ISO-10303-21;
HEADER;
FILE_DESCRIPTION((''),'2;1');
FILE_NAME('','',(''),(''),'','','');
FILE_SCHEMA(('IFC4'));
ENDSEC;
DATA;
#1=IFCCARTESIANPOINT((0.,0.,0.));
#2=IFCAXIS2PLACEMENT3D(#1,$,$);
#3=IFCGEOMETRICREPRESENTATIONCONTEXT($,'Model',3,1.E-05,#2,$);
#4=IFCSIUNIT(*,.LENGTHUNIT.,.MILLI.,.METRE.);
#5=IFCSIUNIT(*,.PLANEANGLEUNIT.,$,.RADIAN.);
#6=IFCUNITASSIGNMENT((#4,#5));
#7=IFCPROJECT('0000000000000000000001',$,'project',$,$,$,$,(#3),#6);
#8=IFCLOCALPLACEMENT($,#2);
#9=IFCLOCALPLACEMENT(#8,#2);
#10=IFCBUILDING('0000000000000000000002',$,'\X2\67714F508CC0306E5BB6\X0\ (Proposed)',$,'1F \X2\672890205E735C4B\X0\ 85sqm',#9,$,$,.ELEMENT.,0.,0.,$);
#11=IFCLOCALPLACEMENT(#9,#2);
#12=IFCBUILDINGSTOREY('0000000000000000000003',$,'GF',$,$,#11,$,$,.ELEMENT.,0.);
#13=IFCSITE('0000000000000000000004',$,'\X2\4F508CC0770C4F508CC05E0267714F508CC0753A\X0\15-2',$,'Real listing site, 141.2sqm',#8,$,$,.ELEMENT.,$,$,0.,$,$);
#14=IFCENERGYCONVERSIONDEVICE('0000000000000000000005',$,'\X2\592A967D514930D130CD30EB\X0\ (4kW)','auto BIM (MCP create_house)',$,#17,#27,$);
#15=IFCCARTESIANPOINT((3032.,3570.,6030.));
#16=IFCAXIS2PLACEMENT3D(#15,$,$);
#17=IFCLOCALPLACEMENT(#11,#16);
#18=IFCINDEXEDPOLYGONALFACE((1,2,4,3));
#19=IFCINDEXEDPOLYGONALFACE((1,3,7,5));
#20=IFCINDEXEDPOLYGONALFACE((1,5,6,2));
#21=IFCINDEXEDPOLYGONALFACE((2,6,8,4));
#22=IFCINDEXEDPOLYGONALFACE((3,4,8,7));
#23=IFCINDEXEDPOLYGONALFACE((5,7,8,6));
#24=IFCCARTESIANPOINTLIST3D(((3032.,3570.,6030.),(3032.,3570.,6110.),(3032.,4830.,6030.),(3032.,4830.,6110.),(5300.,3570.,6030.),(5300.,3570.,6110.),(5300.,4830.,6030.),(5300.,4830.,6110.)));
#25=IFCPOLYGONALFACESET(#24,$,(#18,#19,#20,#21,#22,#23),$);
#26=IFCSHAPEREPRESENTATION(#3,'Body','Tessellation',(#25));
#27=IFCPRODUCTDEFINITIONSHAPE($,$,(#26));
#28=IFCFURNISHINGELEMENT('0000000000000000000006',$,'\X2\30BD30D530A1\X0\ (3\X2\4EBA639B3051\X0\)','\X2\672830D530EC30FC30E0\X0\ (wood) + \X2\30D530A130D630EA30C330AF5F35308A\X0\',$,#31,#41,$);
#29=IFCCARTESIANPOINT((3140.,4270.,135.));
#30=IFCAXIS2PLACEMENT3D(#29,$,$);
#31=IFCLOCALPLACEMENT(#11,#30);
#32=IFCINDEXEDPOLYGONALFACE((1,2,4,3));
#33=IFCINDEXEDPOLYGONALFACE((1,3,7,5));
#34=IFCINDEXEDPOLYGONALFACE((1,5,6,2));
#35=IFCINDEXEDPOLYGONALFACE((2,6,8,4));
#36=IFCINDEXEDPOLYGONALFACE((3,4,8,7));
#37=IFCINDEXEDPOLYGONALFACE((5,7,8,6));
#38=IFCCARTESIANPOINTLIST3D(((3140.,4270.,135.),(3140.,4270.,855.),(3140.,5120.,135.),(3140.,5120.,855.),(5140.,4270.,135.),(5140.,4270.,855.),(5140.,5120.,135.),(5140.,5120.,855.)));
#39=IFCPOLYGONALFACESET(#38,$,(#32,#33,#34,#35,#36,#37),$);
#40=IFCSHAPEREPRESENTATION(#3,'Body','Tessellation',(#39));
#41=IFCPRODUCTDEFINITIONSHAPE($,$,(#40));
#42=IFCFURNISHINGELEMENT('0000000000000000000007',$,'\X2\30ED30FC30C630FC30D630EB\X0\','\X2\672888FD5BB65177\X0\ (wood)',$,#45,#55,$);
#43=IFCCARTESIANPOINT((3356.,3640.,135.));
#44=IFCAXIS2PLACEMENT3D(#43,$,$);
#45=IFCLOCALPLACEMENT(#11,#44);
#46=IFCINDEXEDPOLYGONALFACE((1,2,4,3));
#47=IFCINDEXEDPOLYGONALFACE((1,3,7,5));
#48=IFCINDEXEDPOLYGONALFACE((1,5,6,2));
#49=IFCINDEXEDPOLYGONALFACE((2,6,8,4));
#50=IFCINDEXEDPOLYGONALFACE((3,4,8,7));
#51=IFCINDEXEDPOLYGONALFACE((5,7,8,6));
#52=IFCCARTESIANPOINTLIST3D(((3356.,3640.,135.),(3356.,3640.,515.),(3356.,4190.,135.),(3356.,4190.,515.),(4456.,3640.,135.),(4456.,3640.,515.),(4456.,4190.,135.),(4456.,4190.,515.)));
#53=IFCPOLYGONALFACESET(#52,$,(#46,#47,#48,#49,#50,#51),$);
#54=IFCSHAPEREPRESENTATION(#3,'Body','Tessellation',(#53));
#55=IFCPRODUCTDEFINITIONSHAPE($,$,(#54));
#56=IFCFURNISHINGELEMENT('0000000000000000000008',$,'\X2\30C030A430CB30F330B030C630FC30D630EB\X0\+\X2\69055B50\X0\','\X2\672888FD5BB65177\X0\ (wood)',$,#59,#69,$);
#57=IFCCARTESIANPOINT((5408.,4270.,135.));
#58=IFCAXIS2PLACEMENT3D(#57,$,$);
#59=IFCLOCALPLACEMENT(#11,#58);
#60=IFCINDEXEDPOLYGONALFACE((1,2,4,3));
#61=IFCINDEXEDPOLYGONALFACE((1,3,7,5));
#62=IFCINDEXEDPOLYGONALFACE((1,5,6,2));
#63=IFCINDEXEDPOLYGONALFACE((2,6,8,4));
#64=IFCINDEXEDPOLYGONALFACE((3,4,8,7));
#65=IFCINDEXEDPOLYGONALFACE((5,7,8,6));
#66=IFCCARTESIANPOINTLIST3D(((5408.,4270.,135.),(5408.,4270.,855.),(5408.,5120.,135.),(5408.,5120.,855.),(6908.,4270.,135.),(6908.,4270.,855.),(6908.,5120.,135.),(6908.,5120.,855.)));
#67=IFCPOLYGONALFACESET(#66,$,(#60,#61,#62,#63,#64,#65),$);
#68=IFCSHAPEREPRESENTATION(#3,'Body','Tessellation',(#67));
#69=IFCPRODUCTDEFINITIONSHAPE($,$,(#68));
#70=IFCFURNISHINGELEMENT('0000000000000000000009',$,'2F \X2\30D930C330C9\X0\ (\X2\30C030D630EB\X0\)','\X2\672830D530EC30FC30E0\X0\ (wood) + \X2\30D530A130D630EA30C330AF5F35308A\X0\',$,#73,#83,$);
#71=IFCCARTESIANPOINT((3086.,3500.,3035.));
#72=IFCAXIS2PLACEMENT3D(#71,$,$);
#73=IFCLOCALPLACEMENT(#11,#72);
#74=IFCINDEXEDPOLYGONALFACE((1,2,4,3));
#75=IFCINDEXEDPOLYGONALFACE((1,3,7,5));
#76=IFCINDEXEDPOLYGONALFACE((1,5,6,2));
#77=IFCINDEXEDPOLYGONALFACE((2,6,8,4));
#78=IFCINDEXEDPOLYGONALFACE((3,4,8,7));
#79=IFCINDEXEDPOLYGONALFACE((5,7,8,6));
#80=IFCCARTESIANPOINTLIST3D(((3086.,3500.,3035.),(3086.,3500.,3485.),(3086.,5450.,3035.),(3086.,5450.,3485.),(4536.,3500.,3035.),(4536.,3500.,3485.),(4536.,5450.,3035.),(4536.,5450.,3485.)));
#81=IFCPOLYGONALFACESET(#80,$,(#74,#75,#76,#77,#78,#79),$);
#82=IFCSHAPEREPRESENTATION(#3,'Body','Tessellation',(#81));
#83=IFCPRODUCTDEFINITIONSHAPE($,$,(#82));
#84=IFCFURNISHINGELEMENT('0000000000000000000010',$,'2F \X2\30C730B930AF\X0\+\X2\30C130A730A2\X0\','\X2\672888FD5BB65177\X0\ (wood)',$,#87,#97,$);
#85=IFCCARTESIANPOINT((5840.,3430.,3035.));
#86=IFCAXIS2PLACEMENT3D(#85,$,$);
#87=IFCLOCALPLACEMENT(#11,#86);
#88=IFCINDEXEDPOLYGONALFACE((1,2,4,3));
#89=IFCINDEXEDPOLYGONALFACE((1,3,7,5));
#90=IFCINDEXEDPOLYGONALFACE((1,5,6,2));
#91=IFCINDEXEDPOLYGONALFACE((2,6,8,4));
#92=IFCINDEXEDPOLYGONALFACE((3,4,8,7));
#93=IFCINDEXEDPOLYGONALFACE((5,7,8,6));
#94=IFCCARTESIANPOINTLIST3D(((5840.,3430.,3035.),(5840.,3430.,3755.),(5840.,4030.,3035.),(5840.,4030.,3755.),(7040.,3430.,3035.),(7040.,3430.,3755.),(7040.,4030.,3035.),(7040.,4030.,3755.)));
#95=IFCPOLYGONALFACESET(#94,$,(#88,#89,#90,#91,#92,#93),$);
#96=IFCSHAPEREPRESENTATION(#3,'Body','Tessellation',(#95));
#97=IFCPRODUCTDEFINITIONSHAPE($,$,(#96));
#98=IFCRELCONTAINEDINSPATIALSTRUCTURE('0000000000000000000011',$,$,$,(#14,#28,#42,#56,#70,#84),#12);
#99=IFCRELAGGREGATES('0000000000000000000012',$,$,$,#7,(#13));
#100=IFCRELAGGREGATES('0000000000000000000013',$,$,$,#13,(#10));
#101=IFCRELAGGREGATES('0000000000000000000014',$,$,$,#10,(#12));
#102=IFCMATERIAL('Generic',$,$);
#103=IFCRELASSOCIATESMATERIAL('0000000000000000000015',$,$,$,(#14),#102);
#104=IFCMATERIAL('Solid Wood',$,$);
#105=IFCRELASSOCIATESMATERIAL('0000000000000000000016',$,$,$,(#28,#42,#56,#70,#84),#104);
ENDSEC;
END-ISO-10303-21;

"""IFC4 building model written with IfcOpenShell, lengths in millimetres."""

from ifc_helpers import new_model, si_unit, frame, frame_2d, origin, place, context, project, spatial, rectangle, extrude, material, element, save


model = new_model("IFC4")

# Units and contexts
model_context = context("Model", 3, precision=1e-05, world=origin())
ifc_project = project(units=[si_unit("LENGTHUNIT", "METRE", prefix="MILLI"), si_unit("PLANEANGLEUNIT", "RADIAN")], contexts=[model_context])

# Site, building, storey
site_placement = place(None, origin())
site = spatial("IfcSite", under=ifc_project, at=site_placement, Name="佐賀県佐賀市東佐賀町15-2", ObjectType="Real listing site, 141.2sqm", CompositionType="ELEMENT", RefElevation=0.0)
building_placement = place(site_placement, origin())
building = spatial("IfcBuilding", under=site, at=building_placement, Name="東佐賀の家 (Proposed)", ObjectType="1F 木造平屋 85sqm", CompositionType="ELEMENT", ElevationOfRefHeight=0.0, ElevationOfTerrain=0.0)
storey_placement = place(building_placement, origin())
storey = spatial("IfcBuildingStorey", under=building, at=storey_placement, Name="GF", CompositionType="ELEMENT", Elevation=0.0)

# Shared definitions
ifc_material_1 = material(Name="Solid Wood")

# Shared definitions
ifc_material_2 = material(Name="Generic")

# Energy conversion device
energy_conversion_device_placement = place(storey_placement, frame((3032.0, 3570.0, 6030.0)))
element("IfcEnergyConversionDevice", 1, at=energy_conversion_device_placement, inside=storey, material=ifc_material_2, Name="太陽光パネル (4kW)", Description="auto BIM (MCP create_house)", context=model_context, shape_type="SweptSolid", body=[
    extrude(rectangle(XDim=2268.0, YDim=1260.0, at=frame_2d((1134.0, 630.0))), frame((3032.0, 3570.0, 6030.0)), (0.0, 0.0, 1.0), 80.0),
])

# Furnishing elements
furnishing_1_placement = place(storey_placement, frame((3140.0, 4270.0, 135.0)))
element("IfcFurnishingElement", 2, at=furnishing_1_placement, inside=storey, material=ifc_material_1, Name="ソファ (3人掛け)", Description="木フレーム (wood) + ファブリック張り", context=model_context, shape_type="SweptSolid", body=[
    extrude(rectangle(XDim=2000.0, YDim=850.0, at=frame_2d((1000.0, 425.0))), frame((3140.0, 4270.0, 135.0)), (0.0, 0.0, 1.0), 720.0),
])
furnishing_2_placement = place(storey_placement, frame((3356.0, 3640.0, 135.0)))
element("IfcFurnishingElement", 3, at=furnishing_2_placement, inside=storey, material=ifc_material_1, Name="ローテーブル", Description="木製家具 (wood)", context=model_context, shape_type="SweptSolid", body=[
    extrude(rectangle(XDim=1100.0, YDim=550.0, at=frame_2d((550.0, 275.0))), frame((3356.0, 3640.0, 135.0)), (0.0, 0.0, 1.0), 380.0),
])
furnishing_3_placement = place(storey_placement, frame((5408.0, 4270.0, 135.0)))
element("IfcFurnishingElement", 4, at=furnishing_3_placement, inside=storey, material=ifc_material_1, Name="ダイニングテーブル+椅子", Description="木製家具 (wood)", context=model_context, shape_type="SweptSolid", body=[
    extrude(rectangle(XDim=1500.0, YDim=850.0, at=frame_2d((750.0, 425.0))), frame((5408.0, 4270.0, 135.0)), (0.0, 0.0, 1.0), 720.0),
])
furnishing_4_placement = place(storey_placement, frame((3086.0, 3500.0, 3035.0)))
element("IfcFurnishingElement", 5, at=furnishing_4_placement, inside=storey, material=ifc_material_1, Name="2F ベッド (ダブル)", Description="木フレーム (wood) + ファブリック張り", context=model_context, shape_type="SweptSolid", body=[
    extrude(rectangle(XDim=1450.0, YDim=1950.0, at=frame_2d((725.0, 975.0))), frame((3086.0, 3500.0, 3035.0)), (0.0, 0.0, 1.0), 450.0),
])
furnishing_5_placement = place(storey_placement, frame((5840.0, 3430.0, 3035.0)))
element("IfcFurnishingElement", 6, at=furnishing_5_placement, inside=storey, material=ifc_material_1, Name="2F デスク+チェア", Description="木製家具 (wood)", context=model_context, shape_type="SweptSolid", body=[
    extrude(rectangle(XDim=1200.0, YDim=600.0, at=frame_2d((600.0, 300.0))), frame((5840.0, 3430.0, 3035.0)), (0.0, 0.0, 1.0), 720.0),
])

save(model, "model.ifc")
